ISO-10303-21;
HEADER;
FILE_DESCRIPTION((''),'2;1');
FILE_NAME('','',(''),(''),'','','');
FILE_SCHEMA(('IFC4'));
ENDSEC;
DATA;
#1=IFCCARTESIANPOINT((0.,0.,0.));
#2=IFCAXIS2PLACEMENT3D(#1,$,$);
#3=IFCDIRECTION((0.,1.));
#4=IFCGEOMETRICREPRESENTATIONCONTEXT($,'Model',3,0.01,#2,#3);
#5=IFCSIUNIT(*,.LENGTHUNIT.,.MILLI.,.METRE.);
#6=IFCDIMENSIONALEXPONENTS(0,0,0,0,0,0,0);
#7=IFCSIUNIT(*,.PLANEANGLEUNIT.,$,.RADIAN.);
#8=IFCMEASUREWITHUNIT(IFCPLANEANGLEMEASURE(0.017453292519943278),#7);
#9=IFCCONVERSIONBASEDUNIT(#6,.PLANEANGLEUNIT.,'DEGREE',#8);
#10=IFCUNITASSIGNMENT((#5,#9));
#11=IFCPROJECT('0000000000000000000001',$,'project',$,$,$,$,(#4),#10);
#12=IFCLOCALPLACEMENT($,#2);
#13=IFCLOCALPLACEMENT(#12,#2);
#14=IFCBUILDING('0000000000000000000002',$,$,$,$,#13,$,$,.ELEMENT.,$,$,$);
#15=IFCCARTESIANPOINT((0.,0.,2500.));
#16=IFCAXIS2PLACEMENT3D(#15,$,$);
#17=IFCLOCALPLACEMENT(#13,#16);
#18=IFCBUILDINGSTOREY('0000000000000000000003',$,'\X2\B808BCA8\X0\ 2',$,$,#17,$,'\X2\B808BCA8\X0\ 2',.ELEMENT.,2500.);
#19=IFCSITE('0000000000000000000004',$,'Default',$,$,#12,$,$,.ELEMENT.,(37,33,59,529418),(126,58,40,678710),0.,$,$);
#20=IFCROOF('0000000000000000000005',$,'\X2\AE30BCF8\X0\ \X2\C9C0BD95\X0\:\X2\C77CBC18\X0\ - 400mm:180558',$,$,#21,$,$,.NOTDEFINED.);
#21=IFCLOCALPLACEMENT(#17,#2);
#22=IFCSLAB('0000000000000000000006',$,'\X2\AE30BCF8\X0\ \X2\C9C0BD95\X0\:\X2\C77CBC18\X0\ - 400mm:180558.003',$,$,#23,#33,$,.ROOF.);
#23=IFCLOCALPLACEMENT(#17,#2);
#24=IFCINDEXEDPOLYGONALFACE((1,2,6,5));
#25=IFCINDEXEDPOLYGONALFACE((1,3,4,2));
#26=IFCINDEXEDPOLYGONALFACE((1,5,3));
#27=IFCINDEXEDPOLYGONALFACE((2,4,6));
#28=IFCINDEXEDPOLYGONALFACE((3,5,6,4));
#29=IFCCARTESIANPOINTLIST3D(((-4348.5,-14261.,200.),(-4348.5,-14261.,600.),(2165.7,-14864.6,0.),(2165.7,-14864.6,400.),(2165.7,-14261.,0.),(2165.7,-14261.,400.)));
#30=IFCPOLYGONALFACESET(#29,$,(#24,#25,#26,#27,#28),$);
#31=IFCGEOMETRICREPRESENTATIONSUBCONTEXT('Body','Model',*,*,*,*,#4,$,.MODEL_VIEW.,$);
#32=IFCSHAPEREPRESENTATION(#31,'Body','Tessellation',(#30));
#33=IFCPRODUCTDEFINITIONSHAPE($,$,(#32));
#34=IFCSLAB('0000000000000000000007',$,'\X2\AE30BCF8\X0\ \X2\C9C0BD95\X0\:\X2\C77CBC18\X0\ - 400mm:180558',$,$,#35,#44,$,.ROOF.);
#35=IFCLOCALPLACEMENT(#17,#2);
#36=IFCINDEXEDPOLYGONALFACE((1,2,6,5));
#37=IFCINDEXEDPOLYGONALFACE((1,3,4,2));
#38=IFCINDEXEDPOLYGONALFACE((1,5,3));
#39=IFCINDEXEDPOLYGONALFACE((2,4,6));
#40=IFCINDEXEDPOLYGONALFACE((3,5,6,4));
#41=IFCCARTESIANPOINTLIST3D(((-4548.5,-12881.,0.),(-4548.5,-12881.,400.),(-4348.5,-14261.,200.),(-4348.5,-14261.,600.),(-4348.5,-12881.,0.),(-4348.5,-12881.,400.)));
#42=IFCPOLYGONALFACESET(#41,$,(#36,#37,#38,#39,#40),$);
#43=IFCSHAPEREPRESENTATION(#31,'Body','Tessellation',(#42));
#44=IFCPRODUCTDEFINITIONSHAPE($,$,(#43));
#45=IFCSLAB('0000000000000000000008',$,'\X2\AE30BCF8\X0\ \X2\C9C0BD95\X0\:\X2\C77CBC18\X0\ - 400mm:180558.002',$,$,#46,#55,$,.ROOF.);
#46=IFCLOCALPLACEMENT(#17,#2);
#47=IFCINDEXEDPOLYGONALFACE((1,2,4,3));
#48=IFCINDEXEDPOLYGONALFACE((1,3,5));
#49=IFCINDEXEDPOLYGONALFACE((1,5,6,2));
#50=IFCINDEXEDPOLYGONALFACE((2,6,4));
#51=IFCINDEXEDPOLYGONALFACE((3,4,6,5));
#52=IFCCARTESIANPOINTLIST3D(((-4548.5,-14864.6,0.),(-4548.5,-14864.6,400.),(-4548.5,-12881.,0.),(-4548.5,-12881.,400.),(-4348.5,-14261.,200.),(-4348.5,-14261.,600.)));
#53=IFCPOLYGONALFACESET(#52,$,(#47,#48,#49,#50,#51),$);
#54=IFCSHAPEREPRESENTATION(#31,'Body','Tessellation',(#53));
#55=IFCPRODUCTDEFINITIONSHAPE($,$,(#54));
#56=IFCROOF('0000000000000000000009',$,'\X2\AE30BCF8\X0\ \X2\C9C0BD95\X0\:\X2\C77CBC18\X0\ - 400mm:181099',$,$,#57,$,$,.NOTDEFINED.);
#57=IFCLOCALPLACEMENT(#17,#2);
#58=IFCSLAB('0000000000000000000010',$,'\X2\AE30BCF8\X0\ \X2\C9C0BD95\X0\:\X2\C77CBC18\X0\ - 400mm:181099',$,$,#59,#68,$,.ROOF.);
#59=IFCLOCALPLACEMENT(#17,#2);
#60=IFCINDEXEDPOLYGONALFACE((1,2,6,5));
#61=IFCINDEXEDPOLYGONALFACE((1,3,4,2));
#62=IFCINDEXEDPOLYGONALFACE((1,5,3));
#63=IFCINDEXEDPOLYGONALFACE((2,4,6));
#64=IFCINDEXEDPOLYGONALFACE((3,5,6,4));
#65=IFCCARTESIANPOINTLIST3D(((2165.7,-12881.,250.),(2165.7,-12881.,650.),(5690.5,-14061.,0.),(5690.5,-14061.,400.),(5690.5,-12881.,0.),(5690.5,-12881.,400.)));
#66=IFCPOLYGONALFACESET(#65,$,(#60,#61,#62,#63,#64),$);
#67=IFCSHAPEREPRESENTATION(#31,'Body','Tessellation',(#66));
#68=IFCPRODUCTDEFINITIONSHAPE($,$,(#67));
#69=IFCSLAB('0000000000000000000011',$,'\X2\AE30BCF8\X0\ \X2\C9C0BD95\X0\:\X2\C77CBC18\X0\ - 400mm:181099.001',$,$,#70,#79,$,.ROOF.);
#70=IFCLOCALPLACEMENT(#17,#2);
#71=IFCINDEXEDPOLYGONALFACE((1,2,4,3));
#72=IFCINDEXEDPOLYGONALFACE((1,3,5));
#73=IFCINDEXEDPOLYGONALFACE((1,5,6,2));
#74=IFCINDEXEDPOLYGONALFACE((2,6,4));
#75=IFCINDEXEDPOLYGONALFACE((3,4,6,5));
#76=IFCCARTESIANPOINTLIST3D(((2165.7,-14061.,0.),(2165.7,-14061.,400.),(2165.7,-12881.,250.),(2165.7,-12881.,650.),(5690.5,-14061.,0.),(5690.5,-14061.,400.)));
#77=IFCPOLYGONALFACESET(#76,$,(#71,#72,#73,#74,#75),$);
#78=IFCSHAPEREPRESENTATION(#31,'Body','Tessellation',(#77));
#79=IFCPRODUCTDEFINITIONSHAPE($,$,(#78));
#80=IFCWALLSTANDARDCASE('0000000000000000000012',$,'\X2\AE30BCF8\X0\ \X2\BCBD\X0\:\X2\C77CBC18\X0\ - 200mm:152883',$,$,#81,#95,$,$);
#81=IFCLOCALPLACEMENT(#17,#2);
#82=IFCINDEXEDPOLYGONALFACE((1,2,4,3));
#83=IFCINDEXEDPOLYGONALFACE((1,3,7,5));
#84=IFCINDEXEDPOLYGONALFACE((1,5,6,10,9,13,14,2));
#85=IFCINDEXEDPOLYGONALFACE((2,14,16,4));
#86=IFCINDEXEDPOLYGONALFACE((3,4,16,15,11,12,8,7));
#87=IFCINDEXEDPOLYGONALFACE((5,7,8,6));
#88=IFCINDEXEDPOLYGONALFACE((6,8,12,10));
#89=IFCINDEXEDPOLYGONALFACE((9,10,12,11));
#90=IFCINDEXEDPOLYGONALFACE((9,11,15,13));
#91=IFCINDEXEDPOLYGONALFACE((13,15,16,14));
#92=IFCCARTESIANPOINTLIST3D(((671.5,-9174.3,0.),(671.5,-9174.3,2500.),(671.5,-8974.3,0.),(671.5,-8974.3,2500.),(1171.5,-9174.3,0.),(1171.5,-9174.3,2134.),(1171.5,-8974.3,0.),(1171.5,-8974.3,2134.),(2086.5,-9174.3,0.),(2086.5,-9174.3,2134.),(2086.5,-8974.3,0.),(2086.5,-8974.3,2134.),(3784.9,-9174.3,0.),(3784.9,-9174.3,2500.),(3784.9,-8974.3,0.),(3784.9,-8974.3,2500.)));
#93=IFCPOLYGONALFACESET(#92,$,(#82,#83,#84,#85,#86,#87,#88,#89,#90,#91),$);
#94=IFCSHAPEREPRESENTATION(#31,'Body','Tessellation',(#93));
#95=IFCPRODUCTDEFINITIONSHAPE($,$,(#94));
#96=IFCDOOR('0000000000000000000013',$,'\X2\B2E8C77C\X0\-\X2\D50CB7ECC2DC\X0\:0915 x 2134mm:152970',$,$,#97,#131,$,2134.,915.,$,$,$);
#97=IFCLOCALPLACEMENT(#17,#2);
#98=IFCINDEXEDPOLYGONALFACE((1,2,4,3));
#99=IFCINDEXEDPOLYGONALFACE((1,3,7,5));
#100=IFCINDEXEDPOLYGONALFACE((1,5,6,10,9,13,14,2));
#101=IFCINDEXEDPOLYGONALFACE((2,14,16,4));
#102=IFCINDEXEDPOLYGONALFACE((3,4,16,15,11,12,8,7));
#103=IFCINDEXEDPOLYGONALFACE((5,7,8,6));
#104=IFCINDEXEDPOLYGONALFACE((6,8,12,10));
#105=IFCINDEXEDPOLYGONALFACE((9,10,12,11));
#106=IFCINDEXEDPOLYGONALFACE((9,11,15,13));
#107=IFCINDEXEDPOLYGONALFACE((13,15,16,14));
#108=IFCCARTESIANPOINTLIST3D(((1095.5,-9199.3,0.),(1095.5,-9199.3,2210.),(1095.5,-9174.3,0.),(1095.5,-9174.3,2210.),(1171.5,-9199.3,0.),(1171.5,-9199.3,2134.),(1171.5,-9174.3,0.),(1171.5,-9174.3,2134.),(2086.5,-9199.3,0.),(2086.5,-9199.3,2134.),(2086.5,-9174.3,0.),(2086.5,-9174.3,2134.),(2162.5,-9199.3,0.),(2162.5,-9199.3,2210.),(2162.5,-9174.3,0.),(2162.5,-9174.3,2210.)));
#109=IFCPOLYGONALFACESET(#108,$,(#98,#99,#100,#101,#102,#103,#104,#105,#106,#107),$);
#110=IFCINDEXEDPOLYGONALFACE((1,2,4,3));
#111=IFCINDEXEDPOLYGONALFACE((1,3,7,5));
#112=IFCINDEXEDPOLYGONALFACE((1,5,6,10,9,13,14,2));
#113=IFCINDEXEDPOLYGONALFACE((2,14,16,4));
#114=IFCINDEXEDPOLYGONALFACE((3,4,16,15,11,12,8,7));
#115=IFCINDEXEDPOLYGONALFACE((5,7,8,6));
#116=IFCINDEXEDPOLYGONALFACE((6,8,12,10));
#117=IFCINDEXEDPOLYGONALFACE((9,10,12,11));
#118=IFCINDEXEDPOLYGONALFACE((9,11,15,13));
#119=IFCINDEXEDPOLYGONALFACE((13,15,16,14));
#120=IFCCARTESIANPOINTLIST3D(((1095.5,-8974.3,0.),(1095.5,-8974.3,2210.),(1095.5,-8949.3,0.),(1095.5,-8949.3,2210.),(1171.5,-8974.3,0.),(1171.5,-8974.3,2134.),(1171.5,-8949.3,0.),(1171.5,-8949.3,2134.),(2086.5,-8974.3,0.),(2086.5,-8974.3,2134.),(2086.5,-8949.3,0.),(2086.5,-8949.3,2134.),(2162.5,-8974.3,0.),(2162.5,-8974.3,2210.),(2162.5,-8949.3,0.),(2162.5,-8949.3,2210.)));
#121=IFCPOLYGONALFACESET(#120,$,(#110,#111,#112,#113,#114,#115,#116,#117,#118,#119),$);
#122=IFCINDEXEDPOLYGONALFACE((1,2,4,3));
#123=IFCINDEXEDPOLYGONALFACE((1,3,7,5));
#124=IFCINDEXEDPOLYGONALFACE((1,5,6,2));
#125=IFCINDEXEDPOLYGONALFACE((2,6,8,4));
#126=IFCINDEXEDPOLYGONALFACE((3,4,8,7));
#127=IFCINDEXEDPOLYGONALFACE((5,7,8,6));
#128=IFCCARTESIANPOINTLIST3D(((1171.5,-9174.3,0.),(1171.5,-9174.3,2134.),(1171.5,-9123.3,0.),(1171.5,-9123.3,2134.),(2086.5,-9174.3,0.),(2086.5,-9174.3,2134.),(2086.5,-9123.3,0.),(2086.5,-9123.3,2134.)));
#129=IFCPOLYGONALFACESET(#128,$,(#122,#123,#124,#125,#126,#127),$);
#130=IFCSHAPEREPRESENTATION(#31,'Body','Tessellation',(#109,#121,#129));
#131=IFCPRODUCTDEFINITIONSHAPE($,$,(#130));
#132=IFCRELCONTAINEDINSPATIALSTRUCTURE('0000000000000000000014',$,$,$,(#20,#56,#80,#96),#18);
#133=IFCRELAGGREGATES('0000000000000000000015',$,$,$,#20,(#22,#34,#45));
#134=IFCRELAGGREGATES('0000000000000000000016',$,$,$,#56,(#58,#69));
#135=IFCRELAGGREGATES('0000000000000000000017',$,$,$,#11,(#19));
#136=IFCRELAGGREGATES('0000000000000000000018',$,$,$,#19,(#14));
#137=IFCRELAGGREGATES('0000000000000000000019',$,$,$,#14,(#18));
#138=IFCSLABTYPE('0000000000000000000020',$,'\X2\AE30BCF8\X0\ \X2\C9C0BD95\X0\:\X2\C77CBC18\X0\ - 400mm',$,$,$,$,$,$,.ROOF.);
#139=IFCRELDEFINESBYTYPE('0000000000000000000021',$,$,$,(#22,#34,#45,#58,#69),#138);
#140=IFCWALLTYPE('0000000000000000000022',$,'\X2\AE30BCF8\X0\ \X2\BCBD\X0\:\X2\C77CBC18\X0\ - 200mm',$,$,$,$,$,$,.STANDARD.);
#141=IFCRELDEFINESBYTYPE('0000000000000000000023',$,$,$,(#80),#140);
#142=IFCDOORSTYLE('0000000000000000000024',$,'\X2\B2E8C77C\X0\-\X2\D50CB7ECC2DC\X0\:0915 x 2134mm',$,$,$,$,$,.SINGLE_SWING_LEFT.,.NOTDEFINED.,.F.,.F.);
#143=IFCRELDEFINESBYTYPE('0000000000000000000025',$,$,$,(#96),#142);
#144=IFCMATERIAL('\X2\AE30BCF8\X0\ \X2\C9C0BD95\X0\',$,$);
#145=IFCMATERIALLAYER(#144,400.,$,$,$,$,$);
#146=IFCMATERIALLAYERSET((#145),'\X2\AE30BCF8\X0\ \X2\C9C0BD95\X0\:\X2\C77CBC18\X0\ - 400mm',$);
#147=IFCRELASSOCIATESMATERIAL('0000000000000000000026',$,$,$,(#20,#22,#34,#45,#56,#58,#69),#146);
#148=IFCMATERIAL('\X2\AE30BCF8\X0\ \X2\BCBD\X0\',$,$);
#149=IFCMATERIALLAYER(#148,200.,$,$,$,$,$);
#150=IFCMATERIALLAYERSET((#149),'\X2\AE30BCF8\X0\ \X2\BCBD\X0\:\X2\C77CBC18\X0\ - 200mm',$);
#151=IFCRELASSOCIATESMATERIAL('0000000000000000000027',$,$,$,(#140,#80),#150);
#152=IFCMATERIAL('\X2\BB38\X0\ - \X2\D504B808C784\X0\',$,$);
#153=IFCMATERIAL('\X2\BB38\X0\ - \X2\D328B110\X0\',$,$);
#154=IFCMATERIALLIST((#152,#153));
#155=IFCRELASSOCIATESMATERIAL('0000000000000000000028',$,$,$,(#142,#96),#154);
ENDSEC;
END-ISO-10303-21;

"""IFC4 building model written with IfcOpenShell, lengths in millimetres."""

from ifc_helpers import new_model, entity, si_unit, converted_unit, direction, frame, frame_2d, origin, place, context, subcontext, project, spatial, polyline, rectangle, outline, extrude, source, transform, mapped, material, material_list, layer, layer_set, layer_usage, type_object, type_shapes, element, fill, aggregate, save


model = new_model("IFC4")

# Units and contexts
model_context = context("Model", 3, precision=0.01, world=origin(), true_north=direction((0.0, 1.0)))
body_context = subcontext(model_context, "Body", "Model", "MODEL_VIEW")
ifc_project = project(units=[si_unit("LENGTHUNIT", "METRE", prefix="MILLI"), converted_unit("PLANEANGLEUNIT", "DEGREE", entity("IfcPlaneAngleMeasure", 0.017453292519943278), si_unit("PLANEANGLEUNIT", "RADIAN"), dimensions=[0, 0, 0, 0, 0, 0, 0])], contexts=[model_context])

# Site, building, storey
site_placement = place(None, origin())
site = spatial("IfcSite", under=ifc_project, at=site_placement, Name="Default", CompositionType="ELEMENT", RefLatitude=(37, 33, 59, 529418), RefLongitude=(126, 58, 40, 678710), RefElevation=0.0)
building_placement = place(site_placement, origin())
building = spatial("IfcBuilding", under=site, at=building_placement, CompositionType="ELEMENT")
storey_placement = place(building_placement, frame((0.0, 0.0, 2500.0)))
storey = spatial("IfcBuildingStorey", under=building, at=storey_placement, Name="레벨 2", LongName="레벨 2", CompositionType="ELEMENT", Elevation=2500.0)

# Roofs, slabs
ifc_material_1 = material(Name="기본 지붕")
ifc_layer_1 = layer(ifc_material_1, 400.0)
ifc_layer_set_1 = layer_set([ifc_layer_1], Name="기본 지붕:일반 - 400mm")
roof_1_placement = place(storey_placement, frame((-4548.5, -14864.6, 0.0)))
roof_1 = element("IfcRoof", 1, at=roof_1_placement, inside=storey, material=ifc_layer_set_1, Name="기본 지붕:일반 - 400mm:180558", PredefinedType="NOTDEFINED")
slab_type = type_object("IfcSlabType", Name="기본 지붕:일반 - 400mm", PredefinedType="ROOF")
slab_1_placement = place(roof_1_placement, origin())
slab_1 = element("IfcSlab", 2, at=slab_1_placement, type_object=slab_type, material=ifc_layer_set_1, Name="기본 지붕:일반 - 400mm:180558.003", PredefinedType="ROOF", context=body_context, shape_type="SweptSolid", body=[
    extrude(outline(polyline([(3258.6, 301.8), (-3258.6, 301.8), (3258.6, -301.8), (3258.6, 301.8)])), frame((3457.1, 301.8, 100.0), z_axis=(0.030688, 0.0, 0.999529), x_axis=(0.999529, 0.0, -0.030688)), (-0.030688, 0.0, 0.999529), 400.0),
])
slab_2_placement = place(roof_1_placement, origin())
slab_2 = element("IfcSlab", 3, at=slab_2_placement, type_object=slab_type, material=ifc_layer_set_1, Name="기본 지붕:일반 - 400mm:180558", PredefinedType="ROOF", context=body_context, shape_type="SweptSolid", body=[
    extrude(outline(polyline([(100.0, -697.2), (100.0, 697.2), (-100.0, 697.2), (100.0, -697.2)])), frame((100.0, 1293.7, 100.0), z_axis=(0.0, 0.143429, 0.989661), x_axis=(1.0, 0.0, 0.0)), (0.0, -0.143429, 0.989661), 400.0),
])
slab_3_placement = place(roof_1_placement, origin())
slab_3 = element("IfcSlab", 4, at=slab_3_placement, type_object=slab_type, material=ifc_layer_set_1, Name="기본 지붕:일반 - 400mm:180558.002", PredefinedType="ROOF", context=body_context, shape_type="SweptSolid", body=[
    extrude(outline(polyline([(282.8, -388.2), (0.0, 991.8), (0.0, -991.8), (282.8, -388.2)])), frame((0.0, 991.8, 0.0), z_axis=(-0.707107, 0.0, 0.707107), x_axis=(0.707107, 0.0, 0.707107)), (0.707107, 0.0, 0.707107), 400.0),
])
aggregate(roof_1, [slab_1, slab_2, slab_3])
roof_2_placement = place(storey_placement, frame((2165.7, -14061.0, 0.0)))
roof_2 = element("IfcRoof", 5, at=roof_2_placement, inside=storey, material=ifc_layer_set_1, Name="기본 지붕:일반 - 400mm:181099", PredefinedType="NOTDEFINED")
slab_4_placement = place(roof_2_placement, origin())
slab_4 = element("IfcSlab", 6, at=slab_4_placement, type_object=slab_type, material=ifc_layer_set_1, Name="기본 지붕:일반 - 400mm:181099", PredefinedType="ROOF", context=body_context, shape_type="SweptSolid", body=[
    extrude(outline(polyline([(1766.8, 590.0), (-1766.8, 590.0), (1766.8, -590.0), (1766.8, 590.0)])), frame((1762.4, 590.0, 125.0), z_axis=(0.070749, 0.0, 0.997494), x_axis=(0.997494, 0.0, -0.070749)), (-0.070749, 0.0, 0.997494), 400.0),
])
slab_5_placement = place(roof_2_placement, origin())
slab_5 = element("IfcSlab", 7, at=slab_5_placement, type_object=slab_type, material=ifc_layer_set_1, Name="기본 지붕:일반 - 400mm:181099.001", PredefinedType="ROOF", context=body_context, shape_type="SweptSolid", body=[
    extrude(outline(polyline([(-1762.4, 603.1), (-1762.4, -603.1), (1762.4, -603.1), (-1762.4, 603.1)])), frame((1762.4, 590.0, 125.0), z_axis=(0.0, -0.207264, 0.978285), x_axis=(1.0, 0.0, 0.0)), (0.0, 0.207264, 0.978285), 400.0),
])
aggregate(roof_2, [slab_4, slab_5])

# Wall, opening, door
ifc_material_2 = material(Name="기본 벽")
ifc_layer_2 = layer(ifc_material_2, 200.0)
ifc_layer_set_2 = layer_set([ifc_layer_2], Name="기본 벽:일반 - 200mm")
ifc_layer_usage_1 = layer_usage(ifc_layer_set_2, "AXIS2", "NEGATIVE", 100.0)
wall_type = type_object("IfcWallType", Name="기본 벽:일반 - 200mm", PredefinedType="STANDARD", material=ifc_layer_set_2)
wall_1_placement = place(storey_placement, frame((671.5, -9074.3, 0.0)))
wall_1 = element("IfcWallStandardCase", 8, at=wall_1_placement, inside=storey, type_object=wall_type, material=ifc_layer_usage_1, Name="기본 벽:일반 - 200mm:152883", context=body_context, shape_type="SweptSolid", body=[
    extrude(rectangle(XDim=3113.4, YDim=200.0, at=frame_2d((1556.7, 0.0), x_axis=(-1.0, 0.0))), origin(), (0.0, 0.0, 1.0), 2500.0),
])
opening_1_placement = place(wall_1_placement, frame((1415.0, 100.0, 0.0)))
opening_1 = element("IfcOpeningElement", 9, at=opening_1_placement, cuts=wall_1, ObjectType="Opening", context=body_context, shape_type="SweptSolid", body=[
    extrude(rectangle(XDim=915.0, YDim=2134.0, at=frame_2d((1067.0, 457.5), x_axis=(0.0, -1.0))), frame((0.0, 0.0, 0.0), z_axis=(0.0, -1.0, 0.0), x_axis=(0.0, 0.0, 1.0)), (0.0, 0.0, 1.0), 200.0),
])
ifc_material_3 = material(Name="문 - 프레임")
ifc_material_4 = material(Name="문 - 패널")
ifc_material_list_1 = material_list([ifc_material_3, ifc_material_4])
door_style = type_object("IfcDoorStyle", Name="단일-플러시:0915 x 2134mm", ConstructionType="NOTDEFINED", OperationType="SINGLE_SWING_LEFT", ParameterTakesPrecedence=False, Sizeable=False, material=ifc_material_list_1)
shared_shape_1 = source(origin(), body_context, "Body", "SweptSolid", [
    extrude(outline(polyline([(-533.5, -1124.0), (533.5, -1124.0), (533.5, 1086.0), (457.5, 1086.0), (457.5, -1048.0), (-457.5, -1048.0), (-457.5, 1086.0), (-533.5, 1086.0), (-533.5, -1124.0)])), frame((457.5, 225.0, 1086.0), z_axis=(0.0, -1.0, 0.0), x_axis=(-1.0, 0.0, 0.0)), (0.0, 0.0, 1.0), 25.0),
    extrude(outline(polyline([(-1124.0, -533.5), (1086.0, -533.5), (1086.0, -457.5), (-1048.0, -457.5), (-1048.0, 457.5), (1086.0, 457.5), (1086.0, 533.5), (-1124.0, 533.5), (-1124.0, -533.5)])), frame((457.5, 0.0, 1086.0), z_axis=(0.0, -1.0, 0.0), x_axis=(0.0, 0.0, -1.0)), (0.0, 0.0, 1.0), 25.0),
    extrude(rectangle(XDim=915.0, YDim=51.0, at=frame_2d((0.0, 0.0), x_axis=(1.0, 0.0))), frame((457.5, 174.5, 0.0)), (0.0, 0.0, 1.0), 2134.0),
])
type_shapes(door_style, [shared_shape_1])
door_1_placement = place(opening_1_placement, frame((0.0, 0.0, 0.0), z_axis=(0.0, 0.0, 1.0), x_axis=(-1.0, 0.0, 0.0)))
door_1 = element("IfcDoor", 10, at=door_1_placement, inside=storey, type_object=door_style, material=ifc_material_list_1, Name="단일-플러시:0915 x 2134mm:152970", OverallHeight=2134.0, OverallWidth=915.0, context=body_context, shape_type="MappedRepresentation", body=[
    mapped(shared_shape_1, transform((0.0, 0.0, 0.0), scale=1.0)),
])
fill(opening_1, door_1)

save(model, "model.ifc")
